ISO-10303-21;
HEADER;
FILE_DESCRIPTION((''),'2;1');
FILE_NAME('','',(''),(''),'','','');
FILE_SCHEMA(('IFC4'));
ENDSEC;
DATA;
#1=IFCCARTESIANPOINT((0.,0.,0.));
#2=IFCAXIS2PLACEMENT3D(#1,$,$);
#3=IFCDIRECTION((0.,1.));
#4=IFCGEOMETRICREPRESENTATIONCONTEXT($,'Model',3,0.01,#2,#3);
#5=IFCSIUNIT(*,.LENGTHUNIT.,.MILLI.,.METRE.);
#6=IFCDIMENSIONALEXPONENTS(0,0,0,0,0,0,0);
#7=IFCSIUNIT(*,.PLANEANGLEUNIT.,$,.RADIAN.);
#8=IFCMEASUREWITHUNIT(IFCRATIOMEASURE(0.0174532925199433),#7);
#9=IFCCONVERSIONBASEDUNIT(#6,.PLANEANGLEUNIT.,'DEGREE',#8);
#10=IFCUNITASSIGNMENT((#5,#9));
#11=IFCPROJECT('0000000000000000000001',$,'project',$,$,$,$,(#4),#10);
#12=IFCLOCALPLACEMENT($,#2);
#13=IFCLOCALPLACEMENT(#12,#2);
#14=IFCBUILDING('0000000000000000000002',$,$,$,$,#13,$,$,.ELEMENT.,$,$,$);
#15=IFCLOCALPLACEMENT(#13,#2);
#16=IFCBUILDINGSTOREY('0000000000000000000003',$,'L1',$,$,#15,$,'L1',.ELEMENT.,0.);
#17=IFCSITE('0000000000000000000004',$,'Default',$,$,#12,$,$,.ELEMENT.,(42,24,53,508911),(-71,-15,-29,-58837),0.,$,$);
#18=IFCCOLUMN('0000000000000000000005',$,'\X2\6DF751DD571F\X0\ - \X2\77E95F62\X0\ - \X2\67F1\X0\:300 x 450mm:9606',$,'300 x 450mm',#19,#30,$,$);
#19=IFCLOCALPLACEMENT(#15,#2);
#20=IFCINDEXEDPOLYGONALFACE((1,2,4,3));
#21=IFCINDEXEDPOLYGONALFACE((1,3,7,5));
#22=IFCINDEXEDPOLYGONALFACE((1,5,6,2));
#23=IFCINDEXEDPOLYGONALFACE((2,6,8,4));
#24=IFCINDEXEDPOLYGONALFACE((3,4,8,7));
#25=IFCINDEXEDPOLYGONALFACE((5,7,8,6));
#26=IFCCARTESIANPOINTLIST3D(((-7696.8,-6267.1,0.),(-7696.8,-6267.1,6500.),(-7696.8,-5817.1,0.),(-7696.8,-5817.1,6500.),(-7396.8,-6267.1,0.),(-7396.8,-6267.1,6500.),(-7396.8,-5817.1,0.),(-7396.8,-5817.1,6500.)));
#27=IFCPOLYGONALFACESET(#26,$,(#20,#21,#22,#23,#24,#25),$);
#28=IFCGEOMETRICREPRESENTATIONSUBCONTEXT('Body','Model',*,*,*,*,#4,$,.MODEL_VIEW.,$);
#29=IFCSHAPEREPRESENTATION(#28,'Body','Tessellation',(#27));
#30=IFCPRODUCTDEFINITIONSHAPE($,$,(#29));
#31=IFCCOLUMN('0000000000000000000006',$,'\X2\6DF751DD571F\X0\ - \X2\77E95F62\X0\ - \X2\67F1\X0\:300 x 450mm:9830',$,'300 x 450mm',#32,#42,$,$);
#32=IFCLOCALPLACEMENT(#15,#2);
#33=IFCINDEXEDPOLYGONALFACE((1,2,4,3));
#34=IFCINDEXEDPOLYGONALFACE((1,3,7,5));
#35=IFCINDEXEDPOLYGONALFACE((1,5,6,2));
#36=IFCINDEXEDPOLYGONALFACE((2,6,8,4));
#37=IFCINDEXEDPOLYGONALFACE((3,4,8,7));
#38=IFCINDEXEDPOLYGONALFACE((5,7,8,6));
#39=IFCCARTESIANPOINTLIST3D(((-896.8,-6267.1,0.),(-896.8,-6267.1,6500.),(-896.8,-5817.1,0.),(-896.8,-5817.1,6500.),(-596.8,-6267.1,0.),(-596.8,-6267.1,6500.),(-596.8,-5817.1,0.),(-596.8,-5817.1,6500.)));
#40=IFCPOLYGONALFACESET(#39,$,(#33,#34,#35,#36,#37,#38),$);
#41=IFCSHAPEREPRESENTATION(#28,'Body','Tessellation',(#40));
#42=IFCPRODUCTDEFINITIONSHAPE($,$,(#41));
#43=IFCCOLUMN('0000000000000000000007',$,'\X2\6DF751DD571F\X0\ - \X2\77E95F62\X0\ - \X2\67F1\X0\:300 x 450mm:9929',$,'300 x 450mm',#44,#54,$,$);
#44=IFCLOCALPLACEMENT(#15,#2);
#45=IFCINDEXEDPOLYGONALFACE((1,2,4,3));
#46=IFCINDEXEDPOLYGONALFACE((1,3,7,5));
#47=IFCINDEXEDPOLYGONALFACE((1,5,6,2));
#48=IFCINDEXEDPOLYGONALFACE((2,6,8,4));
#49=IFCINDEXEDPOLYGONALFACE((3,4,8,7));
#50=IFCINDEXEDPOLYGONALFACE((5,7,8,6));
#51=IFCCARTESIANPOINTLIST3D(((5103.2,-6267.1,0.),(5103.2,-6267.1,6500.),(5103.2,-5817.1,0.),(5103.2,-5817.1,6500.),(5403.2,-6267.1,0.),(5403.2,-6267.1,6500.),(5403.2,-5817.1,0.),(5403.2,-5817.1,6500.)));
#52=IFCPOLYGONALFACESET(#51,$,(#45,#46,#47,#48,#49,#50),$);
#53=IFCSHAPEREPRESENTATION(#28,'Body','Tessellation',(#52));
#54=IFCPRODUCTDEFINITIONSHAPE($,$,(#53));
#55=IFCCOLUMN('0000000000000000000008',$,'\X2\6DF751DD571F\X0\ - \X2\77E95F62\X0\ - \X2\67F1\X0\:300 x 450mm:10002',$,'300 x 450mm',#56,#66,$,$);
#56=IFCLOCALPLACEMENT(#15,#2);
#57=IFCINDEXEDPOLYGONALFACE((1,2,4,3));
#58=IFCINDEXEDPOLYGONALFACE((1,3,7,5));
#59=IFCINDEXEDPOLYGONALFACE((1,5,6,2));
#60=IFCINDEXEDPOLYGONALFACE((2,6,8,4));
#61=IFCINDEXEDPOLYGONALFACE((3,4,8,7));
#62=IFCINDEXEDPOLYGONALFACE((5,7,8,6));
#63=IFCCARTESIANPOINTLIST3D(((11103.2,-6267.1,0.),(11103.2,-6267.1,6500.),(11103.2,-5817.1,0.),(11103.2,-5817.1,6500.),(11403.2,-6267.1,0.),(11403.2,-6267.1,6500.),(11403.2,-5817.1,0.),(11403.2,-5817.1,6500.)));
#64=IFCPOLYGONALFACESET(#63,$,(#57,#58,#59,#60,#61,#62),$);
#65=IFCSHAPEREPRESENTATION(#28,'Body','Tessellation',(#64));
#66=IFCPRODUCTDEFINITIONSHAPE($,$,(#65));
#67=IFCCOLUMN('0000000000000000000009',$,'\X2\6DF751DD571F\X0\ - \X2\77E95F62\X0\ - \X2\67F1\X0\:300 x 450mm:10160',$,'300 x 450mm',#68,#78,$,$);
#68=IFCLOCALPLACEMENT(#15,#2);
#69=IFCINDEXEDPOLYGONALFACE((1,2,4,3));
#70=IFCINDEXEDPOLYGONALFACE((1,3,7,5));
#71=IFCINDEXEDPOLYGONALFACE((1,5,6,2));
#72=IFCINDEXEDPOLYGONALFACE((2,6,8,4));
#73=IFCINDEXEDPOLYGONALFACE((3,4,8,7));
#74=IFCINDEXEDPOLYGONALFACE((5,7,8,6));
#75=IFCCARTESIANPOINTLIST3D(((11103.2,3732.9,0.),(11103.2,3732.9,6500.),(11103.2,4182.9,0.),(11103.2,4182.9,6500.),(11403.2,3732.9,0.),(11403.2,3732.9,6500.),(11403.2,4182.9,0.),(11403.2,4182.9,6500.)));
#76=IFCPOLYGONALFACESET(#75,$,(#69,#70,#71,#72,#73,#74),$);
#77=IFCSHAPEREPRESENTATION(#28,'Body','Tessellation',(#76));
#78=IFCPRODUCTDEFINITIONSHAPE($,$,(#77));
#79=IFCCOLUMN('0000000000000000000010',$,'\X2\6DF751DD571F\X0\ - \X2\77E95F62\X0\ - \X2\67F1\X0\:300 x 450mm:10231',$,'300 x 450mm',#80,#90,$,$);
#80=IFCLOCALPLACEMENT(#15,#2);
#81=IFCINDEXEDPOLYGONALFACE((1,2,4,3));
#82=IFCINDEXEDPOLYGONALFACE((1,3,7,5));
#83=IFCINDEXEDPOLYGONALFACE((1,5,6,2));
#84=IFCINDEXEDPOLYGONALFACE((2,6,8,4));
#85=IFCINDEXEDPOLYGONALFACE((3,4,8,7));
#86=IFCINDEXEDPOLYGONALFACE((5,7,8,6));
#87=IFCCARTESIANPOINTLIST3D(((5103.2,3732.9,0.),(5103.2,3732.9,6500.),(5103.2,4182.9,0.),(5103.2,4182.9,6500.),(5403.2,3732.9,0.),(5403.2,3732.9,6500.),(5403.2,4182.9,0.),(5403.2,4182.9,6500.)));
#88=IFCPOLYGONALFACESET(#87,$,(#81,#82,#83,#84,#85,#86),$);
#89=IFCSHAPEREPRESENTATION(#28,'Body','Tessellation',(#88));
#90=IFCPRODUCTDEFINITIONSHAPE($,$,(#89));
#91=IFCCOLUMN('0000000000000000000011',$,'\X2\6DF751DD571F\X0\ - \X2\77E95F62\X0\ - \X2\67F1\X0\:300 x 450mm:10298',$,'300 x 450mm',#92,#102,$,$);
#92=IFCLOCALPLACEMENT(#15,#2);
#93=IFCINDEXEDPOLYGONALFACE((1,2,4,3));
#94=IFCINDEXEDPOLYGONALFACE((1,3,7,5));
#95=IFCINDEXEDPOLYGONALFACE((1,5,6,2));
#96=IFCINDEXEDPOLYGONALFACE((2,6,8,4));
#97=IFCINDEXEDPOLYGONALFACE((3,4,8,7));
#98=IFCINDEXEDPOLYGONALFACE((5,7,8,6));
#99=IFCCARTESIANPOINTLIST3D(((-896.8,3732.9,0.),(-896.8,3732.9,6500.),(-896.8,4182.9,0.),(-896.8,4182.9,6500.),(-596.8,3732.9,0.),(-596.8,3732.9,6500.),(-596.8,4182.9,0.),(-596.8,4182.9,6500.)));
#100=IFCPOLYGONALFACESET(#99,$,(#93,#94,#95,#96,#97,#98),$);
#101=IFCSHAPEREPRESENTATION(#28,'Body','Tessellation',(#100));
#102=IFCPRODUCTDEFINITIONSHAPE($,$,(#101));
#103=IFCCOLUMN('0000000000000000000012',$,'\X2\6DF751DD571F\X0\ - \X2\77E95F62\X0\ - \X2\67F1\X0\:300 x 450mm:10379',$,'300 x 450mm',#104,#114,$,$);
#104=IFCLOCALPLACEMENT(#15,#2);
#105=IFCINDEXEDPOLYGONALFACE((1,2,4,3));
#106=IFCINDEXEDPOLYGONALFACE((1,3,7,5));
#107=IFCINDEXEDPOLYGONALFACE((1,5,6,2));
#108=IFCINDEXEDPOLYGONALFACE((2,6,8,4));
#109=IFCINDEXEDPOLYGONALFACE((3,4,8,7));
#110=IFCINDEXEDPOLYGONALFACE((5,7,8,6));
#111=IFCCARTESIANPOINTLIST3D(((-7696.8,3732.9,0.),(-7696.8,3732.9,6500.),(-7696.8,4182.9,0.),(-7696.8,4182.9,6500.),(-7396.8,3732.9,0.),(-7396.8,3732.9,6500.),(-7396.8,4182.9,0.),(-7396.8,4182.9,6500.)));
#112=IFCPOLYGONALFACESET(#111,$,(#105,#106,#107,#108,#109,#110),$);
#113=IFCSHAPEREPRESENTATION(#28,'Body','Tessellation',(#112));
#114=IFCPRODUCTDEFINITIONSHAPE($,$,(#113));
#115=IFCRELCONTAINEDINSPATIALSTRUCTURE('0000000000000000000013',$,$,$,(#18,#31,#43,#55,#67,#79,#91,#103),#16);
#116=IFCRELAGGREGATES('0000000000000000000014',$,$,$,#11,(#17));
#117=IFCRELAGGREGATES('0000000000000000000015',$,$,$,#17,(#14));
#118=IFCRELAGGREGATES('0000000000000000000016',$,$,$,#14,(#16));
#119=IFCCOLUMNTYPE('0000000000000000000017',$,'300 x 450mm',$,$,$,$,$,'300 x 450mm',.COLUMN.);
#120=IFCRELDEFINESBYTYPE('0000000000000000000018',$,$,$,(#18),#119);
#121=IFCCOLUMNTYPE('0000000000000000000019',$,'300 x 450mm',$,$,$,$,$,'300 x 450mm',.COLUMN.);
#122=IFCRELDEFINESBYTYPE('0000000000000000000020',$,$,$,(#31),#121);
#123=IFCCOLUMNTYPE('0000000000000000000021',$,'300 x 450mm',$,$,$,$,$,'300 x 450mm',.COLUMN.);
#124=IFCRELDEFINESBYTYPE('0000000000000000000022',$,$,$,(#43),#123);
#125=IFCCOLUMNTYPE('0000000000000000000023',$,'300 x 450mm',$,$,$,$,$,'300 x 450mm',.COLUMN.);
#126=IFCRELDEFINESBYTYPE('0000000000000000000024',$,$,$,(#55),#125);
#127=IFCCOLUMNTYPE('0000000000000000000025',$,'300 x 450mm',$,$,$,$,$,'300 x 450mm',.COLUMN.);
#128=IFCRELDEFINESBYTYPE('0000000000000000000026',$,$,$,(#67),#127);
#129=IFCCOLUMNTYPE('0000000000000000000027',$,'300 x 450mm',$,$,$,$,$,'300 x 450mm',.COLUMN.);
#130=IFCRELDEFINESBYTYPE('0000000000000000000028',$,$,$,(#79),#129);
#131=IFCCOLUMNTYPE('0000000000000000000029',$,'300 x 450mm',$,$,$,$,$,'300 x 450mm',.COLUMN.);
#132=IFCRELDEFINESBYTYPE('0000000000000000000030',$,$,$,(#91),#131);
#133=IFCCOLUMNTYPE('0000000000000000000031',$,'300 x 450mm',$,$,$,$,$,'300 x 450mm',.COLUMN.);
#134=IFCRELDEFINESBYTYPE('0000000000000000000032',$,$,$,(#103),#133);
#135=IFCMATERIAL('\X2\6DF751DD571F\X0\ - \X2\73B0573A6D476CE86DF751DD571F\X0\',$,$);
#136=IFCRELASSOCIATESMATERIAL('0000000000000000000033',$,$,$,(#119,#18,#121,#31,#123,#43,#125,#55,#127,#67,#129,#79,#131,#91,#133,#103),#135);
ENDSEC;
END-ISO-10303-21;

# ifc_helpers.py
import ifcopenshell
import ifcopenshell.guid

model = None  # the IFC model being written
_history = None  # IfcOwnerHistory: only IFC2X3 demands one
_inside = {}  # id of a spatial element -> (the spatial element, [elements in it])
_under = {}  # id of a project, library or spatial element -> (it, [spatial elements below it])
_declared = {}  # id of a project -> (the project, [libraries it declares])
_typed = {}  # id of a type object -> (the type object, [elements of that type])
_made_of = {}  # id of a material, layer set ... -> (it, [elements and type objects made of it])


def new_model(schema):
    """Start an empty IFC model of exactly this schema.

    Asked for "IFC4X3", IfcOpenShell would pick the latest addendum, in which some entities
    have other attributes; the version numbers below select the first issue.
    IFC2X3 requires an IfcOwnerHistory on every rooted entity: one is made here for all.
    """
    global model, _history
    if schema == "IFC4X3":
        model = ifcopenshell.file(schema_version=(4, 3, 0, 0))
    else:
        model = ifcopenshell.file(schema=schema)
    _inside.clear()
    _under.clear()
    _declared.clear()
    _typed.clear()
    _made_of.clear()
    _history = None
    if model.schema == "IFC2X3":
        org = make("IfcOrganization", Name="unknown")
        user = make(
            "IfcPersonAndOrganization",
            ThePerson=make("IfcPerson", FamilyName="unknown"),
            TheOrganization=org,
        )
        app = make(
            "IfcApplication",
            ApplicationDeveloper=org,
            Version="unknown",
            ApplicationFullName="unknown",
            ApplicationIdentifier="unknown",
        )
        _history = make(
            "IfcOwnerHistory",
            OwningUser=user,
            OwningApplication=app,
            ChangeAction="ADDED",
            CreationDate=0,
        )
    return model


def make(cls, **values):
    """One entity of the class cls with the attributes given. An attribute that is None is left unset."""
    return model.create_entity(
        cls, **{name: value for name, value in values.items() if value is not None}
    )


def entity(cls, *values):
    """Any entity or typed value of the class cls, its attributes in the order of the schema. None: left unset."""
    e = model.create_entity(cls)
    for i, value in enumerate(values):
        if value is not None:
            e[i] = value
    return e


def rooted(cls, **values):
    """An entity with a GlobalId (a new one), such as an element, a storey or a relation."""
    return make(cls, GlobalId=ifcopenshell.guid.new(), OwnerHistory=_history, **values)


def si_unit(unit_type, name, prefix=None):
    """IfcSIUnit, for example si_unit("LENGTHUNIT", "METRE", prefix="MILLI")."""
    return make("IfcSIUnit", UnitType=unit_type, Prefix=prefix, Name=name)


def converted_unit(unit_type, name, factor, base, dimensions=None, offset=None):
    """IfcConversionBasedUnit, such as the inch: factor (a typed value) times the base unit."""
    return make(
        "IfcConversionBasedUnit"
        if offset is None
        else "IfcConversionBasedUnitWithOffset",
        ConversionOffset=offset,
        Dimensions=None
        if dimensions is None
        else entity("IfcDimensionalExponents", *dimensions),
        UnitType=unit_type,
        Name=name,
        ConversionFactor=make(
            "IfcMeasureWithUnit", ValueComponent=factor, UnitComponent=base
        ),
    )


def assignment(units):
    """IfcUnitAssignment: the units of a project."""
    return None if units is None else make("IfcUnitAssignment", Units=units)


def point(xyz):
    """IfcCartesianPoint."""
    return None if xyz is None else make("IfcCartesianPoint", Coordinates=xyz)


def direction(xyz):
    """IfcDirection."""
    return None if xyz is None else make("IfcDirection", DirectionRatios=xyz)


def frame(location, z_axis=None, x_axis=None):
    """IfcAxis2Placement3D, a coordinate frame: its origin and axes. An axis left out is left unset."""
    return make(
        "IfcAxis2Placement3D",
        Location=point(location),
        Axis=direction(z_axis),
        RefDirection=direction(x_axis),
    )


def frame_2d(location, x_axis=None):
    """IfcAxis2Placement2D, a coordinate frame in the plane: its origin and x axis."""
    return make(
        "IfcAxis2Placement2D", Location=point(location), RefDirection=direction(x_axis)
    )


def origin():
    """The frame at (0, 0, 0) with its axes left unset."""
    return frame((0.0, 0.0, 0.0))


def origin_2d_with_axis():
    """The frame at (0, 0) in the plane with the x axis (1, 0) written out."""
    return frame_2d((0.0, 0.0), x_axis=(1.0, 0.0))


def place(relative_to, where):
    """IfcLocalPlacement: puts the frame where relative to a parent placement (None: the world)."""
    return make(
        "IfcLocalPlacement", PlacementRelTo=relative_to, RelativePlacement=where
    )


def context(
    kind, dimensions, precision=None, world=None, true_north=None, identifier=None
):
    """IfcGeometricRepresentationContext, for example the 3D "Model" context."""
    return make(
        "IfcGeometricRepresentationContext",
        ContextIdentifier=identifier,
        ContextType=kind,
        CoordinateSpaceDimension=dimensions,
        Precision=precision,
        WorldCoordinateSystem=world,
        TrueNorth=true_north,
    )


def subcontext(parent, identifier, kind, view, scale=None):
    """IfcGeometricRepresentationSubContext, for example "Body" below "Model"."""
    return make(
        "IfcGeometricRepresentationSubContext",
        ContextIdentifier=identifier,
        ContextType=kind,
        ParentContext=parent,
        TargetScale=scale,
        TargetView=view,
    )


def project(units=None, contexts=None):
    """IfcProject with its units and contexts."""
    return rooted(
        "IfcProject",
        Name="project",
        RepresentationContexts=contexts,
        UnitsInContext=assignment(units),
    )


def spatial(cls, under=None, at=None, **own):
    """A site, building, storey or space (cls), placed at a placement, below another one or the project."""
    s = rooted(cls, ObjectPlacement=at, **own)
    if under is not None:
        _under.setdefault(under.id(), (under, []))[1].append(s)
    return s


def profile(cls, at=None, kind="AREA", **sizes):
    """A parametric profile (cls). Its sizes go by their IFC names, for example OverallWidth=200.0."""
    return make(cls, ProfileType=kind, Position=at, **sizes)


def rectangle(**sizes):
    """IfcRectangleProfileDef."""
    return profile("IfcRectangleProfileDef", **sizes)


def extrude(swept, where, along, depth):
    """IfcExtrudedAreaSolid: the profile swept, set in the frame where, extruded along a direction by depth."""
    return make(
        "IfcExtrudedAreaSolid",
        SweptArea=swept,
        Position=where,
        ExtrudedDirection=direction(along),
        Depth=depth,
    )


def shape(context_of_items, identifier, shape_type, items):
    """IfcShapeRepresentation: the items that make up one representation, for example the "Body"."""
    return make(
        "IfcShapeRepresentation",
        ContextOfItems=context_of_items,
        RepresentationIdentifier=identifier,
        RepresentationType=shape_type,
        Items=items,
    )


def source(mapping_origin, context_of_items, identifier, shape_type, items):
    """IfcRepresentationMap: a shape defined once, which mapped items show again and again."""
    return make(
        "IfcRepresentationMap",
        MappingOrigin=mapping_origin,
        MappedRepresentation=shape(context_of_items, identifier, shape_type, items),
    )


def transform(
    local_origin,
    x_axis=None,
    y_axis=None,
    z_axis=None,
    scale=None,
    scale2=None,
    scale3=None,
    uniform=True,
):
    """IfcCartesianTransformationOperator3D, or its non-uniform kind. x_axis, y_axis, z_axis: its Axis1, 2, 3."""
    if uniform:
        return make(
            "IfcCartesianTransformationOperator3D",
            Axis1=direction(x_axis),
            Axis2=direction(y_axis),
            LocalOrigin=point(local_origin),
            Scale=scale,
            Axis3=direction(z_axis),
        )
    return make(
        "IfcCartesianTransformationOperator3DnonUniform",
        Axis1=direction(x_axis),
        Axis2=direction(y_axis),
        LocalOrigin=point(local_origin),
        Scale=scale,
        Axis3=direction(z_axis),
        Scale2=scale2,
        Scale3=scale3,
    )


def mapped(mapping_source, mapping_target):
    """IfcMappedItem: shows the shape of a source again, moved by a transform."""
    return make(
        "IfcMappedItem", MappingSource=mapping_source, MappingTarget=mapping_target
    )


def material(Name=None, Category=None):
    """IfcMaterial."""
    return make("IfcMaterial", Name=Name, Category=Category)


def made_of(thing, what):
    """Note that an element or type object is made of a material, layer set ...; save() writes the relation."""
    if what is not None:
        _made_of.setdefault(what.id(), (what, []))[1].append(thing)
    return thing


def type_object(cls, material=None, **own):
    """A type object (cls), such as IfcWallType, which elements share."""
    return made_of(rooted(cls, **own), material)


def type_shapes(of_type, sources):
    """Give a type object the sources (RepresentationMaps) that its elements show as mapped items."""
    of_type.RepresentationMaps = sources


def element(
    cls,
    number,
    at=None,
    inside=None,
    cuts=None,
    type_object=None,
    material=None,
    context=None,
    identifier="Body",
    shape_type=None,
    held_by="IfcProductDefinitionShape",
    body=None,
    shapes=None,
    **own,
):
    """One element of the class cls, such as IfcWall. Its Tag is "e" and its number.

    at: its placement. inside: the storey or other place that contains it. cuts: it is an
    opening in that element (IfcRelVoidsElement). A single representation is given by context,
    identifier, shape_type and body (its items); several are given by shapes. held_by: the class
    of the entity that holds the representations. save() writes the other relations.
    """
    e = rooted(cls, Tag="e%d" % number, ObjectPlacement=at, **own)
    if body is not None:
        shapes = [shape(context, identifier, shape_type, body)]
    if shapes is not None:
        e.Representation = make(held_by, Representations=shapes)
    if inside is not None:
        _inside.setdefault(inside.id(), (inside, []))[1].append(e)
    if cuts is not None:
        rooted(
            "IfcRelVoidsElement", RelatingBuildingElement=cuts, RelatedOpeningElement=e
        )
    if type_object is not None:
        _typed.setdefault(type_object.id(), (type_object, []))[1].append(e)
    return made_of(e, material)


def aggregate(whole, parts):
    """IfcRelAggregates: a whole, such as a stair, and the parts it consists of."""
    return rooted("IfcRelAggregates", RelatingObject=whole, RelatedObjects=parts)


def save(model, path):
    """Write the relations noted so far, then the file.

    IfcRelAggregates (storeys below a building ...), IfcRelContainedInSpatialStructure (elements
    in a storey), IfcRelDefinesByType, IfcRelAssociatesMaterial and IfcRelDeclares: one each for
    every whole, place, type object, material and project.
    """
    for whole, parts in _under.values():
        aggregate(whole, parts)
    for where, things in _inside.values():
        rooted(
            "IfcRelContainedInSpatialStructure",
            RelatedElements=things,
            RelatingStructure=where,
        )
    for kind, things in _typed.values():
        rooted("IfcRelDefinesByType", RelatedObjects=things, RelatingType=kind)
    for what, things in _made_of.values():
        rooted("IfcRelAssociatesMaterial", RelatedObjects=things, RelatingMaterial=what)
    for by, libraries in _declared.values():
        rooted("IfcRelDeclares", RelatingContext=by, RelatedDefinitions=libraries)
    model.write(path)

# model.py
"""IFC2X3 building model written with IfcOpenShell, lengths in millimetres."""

from ifc_helpers import new_model, entity, si_unit, converted_unit, direction, frame, frame_2d, origin, origin_2d_with_axis, place, context, subcontext, project, spatial, rectangle, extrude, source, transform, mapped, material, type_object, type_shapes, element, save


model = new_model("IFC2X3")

# Units and contexts
model_context = context("Model", 3, precision=0.01, world=origin(), true_north=direction((0.0, 1.0)))
body_context = subcontext(model_context, "Body", "Model", "MODEL_VIEW")
ifc_project = project(units=[si_unit("LENGTHUNIT", "METRE", prefix="MILLI"), converted_unit("PLANEANGLEUNIT", "DEGREE", entity("IfcRatioMeasure", 0.0174532925199433), si_unit("PLANEANGLEUNIT", "RADIAN"), dimensions=[0, 0, 0, 0, 0, 0, 0])], contexts=[model_context])

# Site, building, storey
site_placement = place(None, origin())
site = spatial("IfcSite", under=ifc_project, at=site_placement, Name="Default", CompositionType="ELEMENT", RefLatitude=(42, 24, 53, 508911), RefLongitude=(-71, -15, -29, -58837), RefElevation=0.0)
building_placement = place(site_placement, origin())
building = spatial("IfcBuilding", under=site, at=building_placement, CompositionType="ELEMENT")
storey_placement = place(building_placement, origin())
storey = spatial("IfcBuildingStorey", under=building, at=storey_placement, Name="L1", LongName="L1", CompositionType="ELEMENT", Elevation=0.0)

# Columns
ifc_material = material(Name="混凝土 - 现场浇注混凝土")
column_type_1 = type_object("IfcColumnType", Name="300 x 450mm", ElementType="300 x 450mm", PredefinedType="COLUMN", material=ifc_material)
shared_shape_1 = source(origin(), body_context, "Body", "SweptSolid", [
    extrude(rectangle(XDim=450.0, YDim=300.0, at=frame_2d((0.0, 0.0), x_axis=(1.0, 0.0))), frame((-7546.8, -6042.1, 0.0), z_axis=(0.0, 0.0, 1.0), x_axis=(0.0, -1.0, 0.0)), (0.0, 0.0, 1.0), 6500.0),
])
type_shapes(column_type_1, [shared_shape_1])
column_1_placement = place(storey_placement, origin())
element("IfcColumn", 1, at=column_1_placement, inside=storey, type_object=column_type_1, material=ifc_material, Name="混凝土 - 矩形 - 柱:300 x 450mm:9606", ObjectType="300 x 450mm", context=body_context, shape_type="MappedRepresentation", body=[
    mapped(shared_shape_1, transform((0.0, 0.0, 0.0), scale=1.0)),
])
column_type_2 = type_object("IfcColumnType", Name="300 x 450mm", ElementType="300 x 450mm", PredefinedType="COLUMN", material=ifc_material)
shared_shape_2 = source(origin(), body_context, "Body", "SweptSolid", [
    extrude(rectangle(XDim=450.0, YDim=300.0, at=origin_2d_with_axis()), frame((-746.8, -6042.1, 0.0), z_axis=(0.0, 0.0, 1.0), x_axis=(0.0, -1.0, 0.0)), (0.0, 0.0, 1.0), 6500.0),
])
type_shapes(column_type_2, [shared_shape_2])
column_2_placement = place(storey_placement, origin())
element("IfcColumn", 2, at=column_2_placement, inside=storey, type_object=column_type_2, material=ifc_material, Name="混凝土 - 矩形 - 柱:300 x 450mm:9830", ObjectType="300 x 450mm", context=body_context, shape_type="MappedRepresentation", body=[
    mapped(shared_shape_2, transform((0.0, 0.0, 0.0), scale=1.0)),
])
column_type_3 = type_object("IfcColumnType", Name="300 x 450mm", ElementType="300 x 450mm", PredefinedType="COLUMN", material=ifc_material)
shared_shape_3 = source(origin(), body_context, "Body", "SweptSolid", [
    extrude(rectangle(XDim=450.0, YDim=300.0, at=frame_2d((0.0, 0.0), x_axis=(1.0, 0.0))), frame((5253.2, -6042.1, 0.0), z_axis=(0.0, 0.0, 1.0), x_axis=(0.0, -1.0, 0.0)), (0.0, 0.0, 1.0), 6500.0),
])
type_shapes(column_type_3, [shared_shape_3])
column_3_placement = place(storey_placement, origin())
element("IfcColumn", 3, at=column_3_placement, inside=storey, type_object=column_type_3, material=ifc_material, Name="混凝土 - 矩形 - 柱:300 x 450mm:9929", ObjectType="300 x 450mm", context=body_context, shape_type="MappedRepresentation", body=[
    mapped(shared_shape_3, transform((0.0, 0.0, 0.0), scale=1.0)),
])
column_type_4 = type_object("IfcColumnType", Name="300 x 450mm", ElementType="300 x 450mm", PredefinedType="COLUMN", material=ifc_material)
shared_shape_4 = source(origin(), body_context, "Body", "SweptSolid", [
    extrude(rectangle(XDim=450.0, YDim=300.0, at=origin_2d_with_axis()), frame((11253.2, -6042.1, 0.0), z_axis=(0.0, 0.0, 1.0), x_axis=(0.0, -1.0, 0.0)), (0.0, 0.0, 1.0), 6500.0),
])
type_shapes(column_type_4, [shared_shape_4])
column_4_placement = place(storey_placement, origin())
element("IfcColumn", 4, at=column_4_placement, inside=storey, type_object=column_type_4, material=ifc_material, Name="混凝土 - 矩形 - 柱:300 x 450mm:10002", ObjectType="300 x 450mm", context=body_context, shape_type="MappedRepresentation", body=[
    mapped(shared_shape_4, transform((0.0, 0.0, 0.0), scale=1.0)),
])
column_type_5 = type_object("IfcColumnType", Name="300 x 450mm", ElementType="300 x 450mm", PredefinedType="COLUMN", material=ifc_material)
shared_shape_5 = source(origin(), body_context, "Body", "SweptSolid", [
    extrude(rectangle(XDim=450.0, YDim=300.0, at=frame_2d((0.0, 0.0), x_axis=(1.0, 0.0))), frame((11253.2, 3957.9, 0.0), z_axis=(0.0, 0.0, 1.0), x_axis=(0.0, -1.0, 0.0)), (0.0, 0.0, 1.0), 6500.0),
])
type_shapes(column_type_5, [shared_shape_5])
column_5_placement = place(storey_placement, origin())
element("IfcColumn", 5, at=column_5_placement, inside=storey, type_object=column_type_5, material=ifc_material, Name="混凝土 - 矩形 - 柱:300 x 450mm:10160", ObjectType="300 x 450mm", context=body_context, shape_type="MappedRepresentation", body=[
    mapped(shared_shape_5, transform((0.0, 0.0, 0.0), scale=1.0)),
])
column_type_6 = type_object("IfcColumnType", Name="300 x 450mm", ElementType="300 x 450mm", PredefinedType="COLUMN", material=ifc_material)
shared_shape_6 = source(origin(), body_context, "Body", "SweptSolid", [
    extrude(rectangle(XDim=450.0, YDim=300.0, at=frame_2d((0.0, 0.0), x_axis=(1.0, 0.0))), frame((5253.2, 3957.9, 0.0), z_axis=(0.0, 0.0, 1.0), x_axis=(0.0, -1.0, 0.0)), (0.0, 0.0, 1.0), 6500.0),
])
type_shapes(column_type_6, [shared_shape_6])
column_6_placement = place(storey_placement, origin())
element("IfcColumn", 6, at=column_6_placement, inside=storey, type_object=column_type_6, material=ifc_material, Name="混凝土 - 矩形 - 柱:300 x 450mm:10231", ObjectType="300 x 450mm", context=body_context, shape_type="MappedRepresentation", body=[
    mapped(shared_shape_6, transform((0.0, 0.0, 0.0), scale=1.0)),
])
column_type_7 = type_object("IfcColumnType", Name="300 x 450mm", ElementType="300 x 450mm", PredefinedType="COLUMN", material=ifc_material)
shared_shape_7 = source(origin(), body_context, "Body", "SweptSolid", [
    extrude(rectangle(XDim=450.0, YDim=300.0, at=frame_2d((0.0, 0.0), x_axis=(1.0, 0.0))), frame((-746.8, 3957.9, 0.0), z_axis=(0.0, 0.0, 1.0), x_axis=(0.0, -1.0, 0.0)), (0.0, 0.0, 1.0), 6500.0),
])
type_shapes(column_type_7, [shared_shape_7])
column_7_placement = place(storey_placement, origin())
element("IfcColumn", 7, at=column_7_placement, inside=storey, type_object=column_type_7, material=ifc_material, Name="混凝土 - 矩形 - 柱:300 x 450mm:10298", ObjectType="300 x 450mm", context=body_context, shape_type="MappedRepresentation", body=[
    mapped(shared_shape_7, transform((0.0, 0.0, 0.0), scale=1.0)),
])
column_type_8 = type_object("IfcColumnType", Name="300 x 450mm", ElementType="300 x 450mm", PredefinedType="COLUMN", material=ifc_material)
shared_shape_8 = source(origin(), body_context, "Body", "SweptSolid", [
    extrude(rectangle(XDim=450.0, YDim=300.0, at=frame_2d((0.0, 0.0), x_axis=(1.0, 0.0))), frame((-7546.8, 3957.9, 0.0), z_axis=(0.0, 0.0, 1.0), x_axis=(0.0, -1.0, 0.0)), (0.0, 0.0, 1.0), 6500.0),
])
type_shapes(column_type_8, [shared_shape_8])
column_8_placement = place(storey_placement, origin())
element("IfcColumn", 8, at=column_8_placement, inside=storey, type_object=column_type_8, material=ifc_material, Name="混凝土 - 矩形 - 柱:300 x 450mm:10379", ObjectType="300 x 450mm", context=body_context, shape_type="MappedRepresentation", body=[
    mapped(shared_shape_8, transform((0.0, 0.0, 0.0), scale=1.0)),
])

save(model, "model.ifc")
